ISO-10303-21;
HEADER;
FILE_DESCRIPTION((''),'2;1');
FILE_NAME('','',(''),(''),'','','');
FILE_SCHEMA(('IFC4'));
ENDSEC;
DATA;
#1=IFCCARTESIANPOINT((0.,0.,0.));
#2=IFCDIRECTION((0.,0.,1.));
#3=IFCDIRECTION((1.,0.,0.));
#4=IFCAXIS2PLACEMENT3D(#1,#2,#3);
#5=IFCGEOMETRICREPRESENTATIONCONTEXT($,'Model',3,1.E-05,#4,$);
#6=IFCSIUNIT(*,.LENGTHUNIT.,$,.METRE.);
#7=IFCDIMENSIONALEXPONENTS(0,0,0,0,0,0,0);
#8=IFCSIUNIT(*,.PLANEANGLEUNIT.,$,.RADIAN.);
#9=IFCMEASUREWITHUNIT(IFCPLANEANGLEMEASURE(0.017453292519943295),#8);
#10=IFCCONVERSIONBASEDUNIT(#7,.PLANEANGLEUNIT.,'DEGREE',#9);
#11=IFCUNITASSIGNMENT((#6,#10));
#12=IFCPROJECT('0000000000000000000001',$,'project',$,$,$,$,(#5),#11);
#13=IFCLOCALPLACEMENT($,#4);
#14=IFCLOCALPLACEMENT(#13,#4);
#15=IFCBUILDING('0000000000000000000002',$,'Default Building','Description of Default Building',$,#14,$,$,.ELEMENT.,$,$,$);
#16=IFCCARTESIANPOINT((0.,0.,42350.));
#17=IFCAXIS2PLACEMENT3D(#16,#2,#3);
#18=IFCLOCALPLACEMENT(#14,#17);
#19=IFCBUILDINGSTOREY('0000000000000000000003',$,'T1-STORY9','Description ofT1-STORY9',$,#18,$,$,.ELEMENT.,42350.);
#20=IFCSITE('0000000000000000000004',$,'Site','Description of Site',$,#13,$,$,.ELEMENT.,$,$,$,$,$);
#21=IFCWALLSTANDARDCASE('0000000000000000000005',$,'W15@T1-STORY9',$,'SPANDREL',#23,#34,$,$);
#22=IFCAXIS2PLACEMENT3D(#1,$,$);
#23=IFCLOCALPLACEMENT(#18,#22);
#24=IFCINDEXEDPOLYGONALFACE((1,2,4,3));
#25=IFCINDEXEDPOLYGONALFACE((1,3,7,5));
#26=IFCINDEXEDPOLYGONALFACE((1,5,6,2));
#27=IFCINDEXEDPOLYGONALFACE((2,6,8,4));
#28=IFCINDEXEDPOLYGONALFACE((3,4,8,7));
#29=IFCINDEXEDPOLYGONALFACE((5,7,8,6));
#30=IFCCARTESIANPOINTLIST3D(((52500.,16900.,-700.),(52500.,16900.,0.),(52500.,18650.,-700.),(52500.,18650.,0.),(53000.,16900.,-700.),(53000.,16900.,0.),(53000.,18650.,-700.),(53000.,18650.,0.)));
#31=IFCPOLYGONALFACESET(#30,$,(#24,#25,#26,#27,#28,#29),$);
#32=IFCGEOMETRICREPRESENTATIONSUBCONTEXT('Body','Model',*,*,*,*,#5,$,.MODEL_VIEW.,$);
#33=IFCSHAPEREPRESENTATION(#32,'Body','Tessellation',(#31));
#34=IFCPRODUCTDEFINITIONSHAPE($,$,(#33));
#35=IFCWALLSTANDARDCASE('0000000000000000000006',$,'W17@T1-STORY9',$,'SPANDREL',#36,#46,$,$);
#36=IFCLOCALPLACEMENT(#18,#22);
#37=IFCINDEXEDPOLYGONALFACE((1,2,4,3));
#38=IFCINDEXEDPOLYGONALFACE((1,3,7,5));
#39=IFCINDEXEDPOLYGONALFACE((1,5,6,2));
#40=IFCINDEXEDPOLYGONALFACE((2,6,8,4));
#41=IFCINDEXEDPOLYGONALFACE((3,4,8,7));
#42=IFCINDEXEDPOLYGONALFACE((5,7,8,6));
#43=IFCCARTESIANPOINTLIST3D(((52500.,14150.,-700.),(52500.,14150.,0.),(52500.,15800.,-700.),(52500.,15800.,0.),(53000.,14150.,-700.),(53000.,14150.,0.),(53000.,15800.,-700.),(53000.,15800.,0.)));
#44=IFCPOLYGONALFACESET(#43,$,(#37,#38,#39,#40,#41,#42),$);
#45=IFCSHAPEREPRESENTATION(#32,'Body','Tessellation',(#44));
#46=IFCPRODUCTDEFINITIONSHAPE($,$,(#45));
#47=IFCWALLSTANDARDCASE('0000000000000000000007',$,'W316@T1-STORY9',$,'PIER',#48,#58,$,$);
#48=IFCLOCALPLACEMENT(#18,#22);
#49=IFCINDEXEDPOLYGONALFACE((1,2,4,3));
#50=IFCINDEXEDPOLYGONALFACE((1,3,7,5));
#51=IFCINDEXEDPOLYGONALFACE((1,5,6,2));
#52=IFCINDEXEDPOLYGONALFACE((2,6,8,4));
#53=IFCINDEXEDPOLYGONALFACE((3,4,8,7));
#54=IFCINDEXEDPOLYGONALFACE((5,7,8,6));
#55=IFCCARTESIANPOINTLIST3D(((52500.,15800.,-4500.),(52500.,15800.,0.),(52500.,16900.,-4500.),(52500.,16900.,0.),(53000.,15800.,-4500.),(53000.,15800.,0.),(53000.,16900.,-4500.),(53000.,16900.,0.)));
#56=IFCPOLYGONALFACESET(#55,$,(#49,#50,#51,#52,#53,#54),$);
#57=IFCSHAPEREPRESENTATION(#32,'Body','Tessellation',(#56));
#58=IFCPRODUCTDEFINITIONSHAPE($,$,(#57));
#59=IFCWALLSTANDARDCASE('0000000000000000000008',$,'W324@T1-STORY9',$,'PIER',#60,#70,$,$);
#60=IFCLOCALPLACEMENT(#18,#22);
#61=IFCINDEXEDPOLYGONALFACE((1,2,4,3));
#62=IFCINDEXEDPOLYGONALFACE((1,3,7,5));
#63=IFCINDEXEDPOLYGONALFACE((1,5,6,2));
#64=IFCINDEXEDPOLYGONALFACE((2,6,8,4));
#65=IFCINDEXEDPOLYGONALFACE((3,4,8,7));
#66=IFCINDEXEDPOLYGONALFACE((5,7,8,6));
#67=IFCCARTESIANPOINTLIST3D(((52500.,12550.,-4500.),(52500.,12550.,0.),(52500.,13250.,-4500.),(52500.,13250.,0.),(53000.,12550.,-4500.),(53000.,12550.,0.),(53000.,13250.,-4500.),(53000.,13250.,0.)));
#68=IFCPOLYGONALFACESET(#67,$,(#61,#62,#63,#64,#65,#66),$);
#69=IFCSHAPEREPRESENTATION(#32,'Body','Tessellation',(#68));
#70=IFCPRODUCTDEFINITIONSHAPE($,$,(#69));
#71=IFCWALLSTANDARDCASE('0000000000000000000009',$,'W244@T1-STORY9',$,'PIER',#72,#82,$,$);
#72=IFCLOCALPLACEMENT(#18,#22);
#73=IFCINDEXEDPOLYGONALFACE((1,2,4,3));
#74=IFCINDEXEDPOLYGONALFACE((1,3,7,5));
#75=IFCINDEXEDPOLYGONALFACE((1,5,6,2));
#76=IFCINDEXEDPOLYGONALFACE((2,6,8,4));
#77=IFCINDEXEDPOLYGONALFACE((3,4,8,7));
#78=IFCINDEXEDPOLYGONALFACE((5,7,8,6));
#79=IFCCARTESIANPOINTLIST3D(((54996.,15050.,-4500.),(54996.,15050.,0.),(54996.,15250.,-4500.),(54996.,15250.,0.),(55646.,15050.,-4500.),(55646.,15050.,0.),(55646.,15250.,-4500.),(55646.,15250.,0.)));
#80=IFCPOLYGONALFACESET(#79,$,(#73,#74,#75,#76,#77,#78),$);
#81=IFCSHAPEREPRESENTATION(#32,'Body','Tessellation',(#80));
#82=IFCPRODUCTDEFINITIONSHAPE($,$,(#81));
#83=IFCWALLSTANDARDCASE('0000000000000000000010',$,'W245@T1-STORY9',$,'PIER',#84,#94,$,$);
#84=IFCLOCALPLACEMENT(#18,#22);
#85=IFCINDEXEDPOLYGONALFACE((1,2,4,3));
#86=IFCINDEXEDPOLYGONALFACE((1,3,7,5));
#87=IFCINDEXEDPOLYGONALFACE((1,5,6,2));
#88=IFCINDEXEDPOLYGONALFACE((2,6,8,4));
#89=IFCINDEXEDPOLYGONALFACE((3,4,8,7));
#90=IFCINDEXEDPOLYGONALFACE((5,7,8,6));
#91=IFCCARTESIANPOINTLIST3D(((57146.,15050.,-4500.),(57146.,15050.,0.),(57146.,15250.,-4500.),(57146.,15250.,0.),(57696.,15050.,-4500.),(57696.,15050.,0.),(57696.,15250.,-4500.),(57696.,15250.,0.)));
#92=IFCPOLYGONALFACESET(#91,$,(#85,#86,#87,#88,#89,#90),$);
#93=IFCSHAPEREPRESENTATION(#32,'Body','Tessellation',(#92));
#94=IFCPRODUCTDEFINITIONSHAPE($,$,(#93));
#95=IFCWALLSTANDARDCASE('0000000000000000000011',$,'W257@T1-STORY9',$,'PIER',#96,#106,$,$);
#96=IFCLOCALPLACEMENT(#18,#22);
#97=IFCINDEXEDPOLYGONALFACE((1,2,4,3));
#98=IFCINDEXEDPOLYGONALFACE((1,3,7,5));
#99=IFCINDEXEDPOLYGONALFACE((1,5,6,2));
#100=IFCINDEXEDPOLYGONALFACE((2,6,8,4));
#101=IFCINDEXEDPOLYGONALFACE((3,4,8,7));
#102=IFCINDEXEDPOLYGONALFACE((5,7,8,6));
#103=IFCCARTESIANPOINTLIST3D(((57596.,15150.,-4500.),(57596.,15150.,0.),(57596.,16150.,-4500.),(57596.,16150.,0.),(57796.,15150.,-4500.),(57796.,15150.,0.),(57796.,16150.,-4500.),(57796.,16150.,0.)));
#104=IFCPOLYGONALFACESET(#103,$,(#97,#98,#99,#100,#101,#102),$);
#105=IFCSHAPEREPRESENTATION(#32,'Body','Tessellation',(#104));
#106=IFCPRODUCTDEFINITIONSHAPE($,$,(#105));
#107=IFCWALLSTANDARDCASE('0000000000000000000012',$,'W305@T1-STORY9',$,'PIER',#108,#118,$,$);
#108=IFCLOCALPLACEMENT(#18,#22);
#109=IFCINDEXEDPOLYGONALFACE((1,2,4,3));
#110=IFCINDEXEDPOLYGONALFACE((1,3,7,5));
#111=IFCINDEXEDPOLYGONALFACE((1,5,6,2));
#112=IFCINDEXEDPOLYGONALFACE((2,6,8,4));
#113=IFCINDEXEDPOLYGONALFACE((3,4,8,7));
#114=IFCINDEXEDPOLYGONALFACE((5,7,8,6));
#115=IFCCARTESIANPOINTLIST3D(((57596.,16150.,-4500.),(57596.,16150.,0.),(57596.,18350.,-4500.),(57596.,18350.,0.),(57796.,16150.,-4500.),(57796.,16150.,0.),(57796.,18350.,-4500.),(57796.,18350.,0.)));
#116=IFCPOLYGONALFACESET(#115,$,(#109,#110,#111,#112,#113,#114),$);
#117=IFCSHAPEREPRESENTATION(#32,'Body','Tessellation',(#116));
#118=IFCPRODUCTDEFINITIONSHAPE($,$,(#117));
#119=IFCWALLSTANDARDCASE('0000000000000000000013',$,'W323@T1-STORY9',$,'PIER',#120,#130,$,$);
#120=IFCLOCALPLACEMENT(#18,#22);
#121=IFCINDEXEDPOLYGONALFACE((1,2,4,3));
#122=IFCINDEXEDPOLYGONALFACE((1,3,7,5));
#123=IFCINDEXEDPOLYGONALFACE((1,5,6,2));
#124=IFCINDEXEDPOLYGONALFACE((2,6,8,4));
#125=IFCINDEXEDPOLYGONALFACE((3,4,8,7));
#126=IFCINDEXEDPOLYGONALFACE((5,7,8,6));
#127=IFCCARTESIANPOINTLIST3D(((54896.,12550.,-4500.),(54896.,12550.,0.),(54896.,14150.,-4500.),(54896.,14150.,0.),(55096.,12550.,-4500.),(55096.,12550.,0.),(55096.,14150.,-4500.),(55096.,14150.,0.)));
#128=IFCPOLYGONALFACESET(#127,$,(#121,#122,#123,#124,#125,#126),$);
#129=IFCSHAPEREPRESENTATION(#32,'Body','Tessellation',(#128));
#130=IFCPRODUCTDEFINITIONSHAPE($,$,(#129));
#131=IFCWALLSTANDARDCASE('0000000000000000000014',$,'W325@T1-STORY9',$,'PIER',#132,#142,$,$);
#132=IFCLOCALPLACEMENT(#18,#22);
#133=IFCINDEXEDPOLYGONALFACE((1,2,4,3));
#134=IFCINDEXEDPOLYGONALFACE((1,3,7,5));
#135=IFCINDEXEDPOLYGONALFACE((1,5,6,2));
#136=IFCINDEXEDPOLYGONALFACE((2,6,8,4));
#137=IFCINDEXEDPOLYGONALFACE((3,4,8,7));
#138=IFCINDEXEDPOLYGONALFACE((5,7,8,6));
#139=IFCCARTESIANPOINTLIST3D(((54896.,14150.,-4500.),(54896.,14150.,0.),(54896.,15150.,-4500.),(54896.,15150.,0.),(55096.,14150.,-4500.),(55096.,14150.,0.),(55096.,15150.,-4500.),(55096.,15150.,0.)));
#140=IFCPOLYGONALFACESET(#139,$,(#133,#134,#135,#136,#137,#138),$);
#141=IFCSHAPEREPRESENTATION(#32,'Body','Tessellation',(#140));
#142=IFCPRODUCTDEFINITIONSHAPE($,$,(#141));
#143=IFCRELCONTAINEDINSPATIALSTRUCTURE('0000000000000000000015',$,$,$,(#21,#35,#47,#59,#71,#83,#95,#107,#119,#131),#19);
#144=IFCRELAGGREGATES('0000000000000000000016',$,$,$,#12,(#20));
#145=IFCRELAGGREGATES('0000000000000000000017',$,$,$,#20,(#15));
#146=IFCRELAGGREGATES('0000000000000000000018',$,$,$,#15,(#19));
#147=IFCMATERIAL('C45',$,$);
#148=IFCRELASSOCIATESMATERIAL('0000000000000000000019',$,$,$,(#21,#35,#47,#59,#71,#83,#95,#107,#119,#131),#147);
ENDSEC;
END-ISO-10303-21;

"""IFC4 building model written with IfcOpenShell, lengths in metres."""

from ifc_helpers import new_model, entity, si_unit, converted_unit, frame, origin_with_axes, place, context, subcontext, project, spatial, indexed_curve, outline, extrude, material, element, save


model = new_model("IFC4")

# Units and contexts
model_context = context("Model", 3, precision=1e-05, world=origin_with_axes())
body_context = subcontext(model_context, "Body", "Model", "MODEL_VIEW")
ifc_project = project(units=[si_unit("LENGTHUNIT", "METRE"), converted_unit("PLANEANGLEUNIT", "DEGREE", entity("IfcPlaneAngleMeasure", 0.017453292519943295), si_unit("PLANEANGLEUNIT", "RADIAN"), dimensions=[0, 0, 0, 0, 0, 0, 0])], contexts=[model_context])

# Site, building, storey
site_placement = place(None, origin_with_axes())
site = spatial("IfcSite", under=ifc_project, at=site_placement, Name="Site", Description="Description of Site", CompositionType="ELEMENT")
building_placement = place(site_placement, origin_with_axes())
building = spatial("IfcBuilding", under=site, at=building_placement, Name="Default Building", Description="Description of Default Building", CompositionType="ELEMENT")
storey_placement = place(building_placement, frame((0.0, 0.0, 42350.0), z_axis=(0.0, 0.0, 1.0), x_axis=(1.0, 0.0, 0.0)))
storey = spatial("IfcBuildingStorey", under=building, at=storey_placement, Name="T1-STORY9", Description="Description ofT1-STORY9", CompositionType="ELEMENT", Elevation=42350.0)

# Shared definitions
ifc_material_1 = material(Name="C45")

# Walls
wall_1_placement = place(storey_placement, frame((52750.0, 16900.0, -700.0), z_axis=(0.0, 0.0, 1.0), x_axis=(0.0, 1.0, 0.0)))
element("IfcWallStandardCase", 1, at=wall_1_placement, inside=storey, material=ifc_material_1, Name="W15@T1-STORY9", ObjectType="SPANDREL", context=body_context, shape_type="SweptSolid", body=[
    extrude(outline(indexed_curve([(0.0, -250.0), (0.0, 250.0), (1750.0, 250.0), (1750.0, -250.0), (0.0, -250.0)], self_intersect=False)), origin_with_axes(), (0.0, 0.0, 1.0), 700.0),
])
wall_2_placement = place(storey_placement, frame((52750.0, 14150.0, -700.0), z_axis=(0.0, 0.0, 1.0), x_axis=(0.0, 1.0, 0.0)))
element("IfcWallStandardCase", 2, at=wall_2_placement, inside=storey, material=ifc_material_1, Name="W17@T1-STORY9", ObjectType="SPANDREL", context=body_context, shape_type="SweptSolid", body=[
    extrude(outline(indexed_curve([(0.0, -250.0), (0.0, 250.0), (1650.0, 250.0), (1650.0, -250.0), (0.0, -250.0)], self_intersect=False)), origin_with_axes(), (0.0, 0.0, 1.0), 700.0),
])
wall_3_placement = place(storey_placement, frame((52750.0, 15800.0, -4500.0), z_axis=(0.0, 0.0, 1.0), x_axis=(0.0, 1.0, 0.0)))
element("IfcWallStandardCase", 3, at=wall_3_placement, inside=storey, material=ifc_material_1, Name="W316@T1-STORY9", ObjectType="PIER", context=body_context, shape_type="SweptSolid", body=[
    extrude(outline(indexed_curve([(0.0, -250.0), (0.0, 250.0), (1100.0, 250.0), (1100.0, -250.0), (0.0, -250.0)], self_intersect=False)), origin_with_axes(), (0.0, 0.0, 1.0), 4500.0),
])
wall_4_placement = place(storey_placement, frame((52750.0, 12550.0, -4500.0), z_axis=(0.0, 0.0, 1.0), x_axis=(0.0, 1.0, 0.0)))
element("IfcWallStandardCase", 4, at=wall_4_placement, inside=storey, material=ifc_material_1, Name="W324@T1-STORY9", ObjectType="PIER", context=body_context, shape_type="SweptSolid", body=[
    extrude(outline(indexed_curve([(0.0, -250.0), (0.0, 250.0), (700.0, 250.0), (700.0, -250.0), (0.0, -250.0)], self_intersect=False)), origin_with_axes(), (0.0, 0.0, 1.0), 4500.0),
])
wall_5_placement = place(storey_placement, frame((54996.0, 15150.0, -4500.0), z_axis=(0.0, 0.0, 1.0), x_axis=(1.0, 0.0, 0.0)))
element("IfcWallStandardCase", 5, at=wall_5_placement, inside=storey, material=ifc_material_1, Name="W244@T1-STORY9", ObjectType="PIER", context=body_context, shape_type="SweptSolid", body=[
    extrude(outline(indexed_curve([(0.0, -100.0), (0.0, 100.0), (650.0, 100.0), (650.0, -100.0), (0.0, -100.0)], self_intersect=False)), origin_with_axes(), (0.0, 0.0, 1.0), 4500.0),
])
wall_6_placement = place(storey_placement, frame((57146.0, 15150.0, -4500.0), z_axis=(0.0, 0.0, 1.0), x_axis=(1.0, 0.0, 0.0)))
element("IfcWallStandardCase", 6, at=wall_6_placement, inside=storey, material=ifc_material_1, Name="W245@T1-STORY9", ObjectType="PIER", context=body_context, shape_type="SweptSolid", body=[
    extrude(outline(indexed_curve([(0.0, -100.0), (0.0, 100.0), (550.0, 100.0), (550.0, -100.0), (0.0, -100.0)], self_intersect=False)), origin_with_axes(), (0.0, 0.0, 1.0), 4500.0),
])
wall_7_placement = place(storey_placement, frame((57696.0, 15150.0, -4500.0), z_axis=(0.0, 0.0, 1.0), x_axis=(0.0, 1.0, 0.0)))
element("IfcWallStandardCase", 7, at=wall_7_placement, inside=storey, material=ifc_material_1, Name="W257@T1-STORY9", ObjectType="PIER", context=body_context, shape_type="SweptSolid", body=[
    extrude(outline(indexed_curve([(0.0, -100.0), (0.0, 100.0), (1000.0, 100.0), (1000.0, -100.0), (0.0, -100.0)], self_intersect=False)), origin_with_axes(), (0.0, 0.0, 1.0), 4500.0),
])
wall_8_placement = place(storey_placement, frame((57696.0, 16150.0, -4500.0), z_axis=(0.0, 0.0, 1.0), x_axis=(0.0, 1.0, 0.0)))
element("IfcWallStandardCase", 8, at=wall_8_placement, inside=storey, material=ifc_material_1, Name="W305@T1-STORY9", ObjectType="PIER", context=body_context, shape_type="SweptSolid", body=[
    extrude(outline(indexed_curve([(0.0, -100.0), (0.0, 100.0), (2200.0, 100.0), (2200.0, -100.0), (0.0, -100.0)], self_intersect=False)), origin_with_axes(), (0.0, 0.0, 1.0), 4500.0),
])
wall_9_placement = place(storey_placement, frame((54996.0, 12550.0, -4500.0), z_axis=(0.0, 0.0, 1.0), x_axis=(0.0, 1.0, 0.0)))
element("IfcWallStandardCase", 9, at=wall_9_placement, inside=storey, material=ifc_material_1, Name="W323@T1-STORY9", ObjectType="PIER", context=body_context, shape_type="SweptSolid", body=[
    extrude(outline(indexed_curve([(0.0, -100.0), (0.0, 100.0), (1600.0, 100.0), (1600.0, -100.0), (0.0, -100.0)], self_intersect=False)), origin_with_axes(), (0.0, 0.0, 1.0), 4500.0),
])
wall_10_placement = place(storey_placement, frame((54996.0, 14150.0, -4500.0), z_axis=(0.0, 0.0, 1.0), x_axis=(0.0, 1.0, 0.0)))
element("IfcWallStandardCase", 10, at=wall_10_placement, inside=storey, material=ifc_material_1, Name="W325@T1-STORY9", ObjectType="PIER", context=body_context, shape_type="SweptSolid", body=[
    extrude(outline(indexed_curve([(0.0, -100.0), (0.0, 100.0), (1000.0, 100.0), (1000.0, -100.0), (0.0, -100.0)], self_intersect=False)), origin_with_axes(), (0.0, 0.0, 1.0), 4500.0),
])

save(model, "model.ifc")
